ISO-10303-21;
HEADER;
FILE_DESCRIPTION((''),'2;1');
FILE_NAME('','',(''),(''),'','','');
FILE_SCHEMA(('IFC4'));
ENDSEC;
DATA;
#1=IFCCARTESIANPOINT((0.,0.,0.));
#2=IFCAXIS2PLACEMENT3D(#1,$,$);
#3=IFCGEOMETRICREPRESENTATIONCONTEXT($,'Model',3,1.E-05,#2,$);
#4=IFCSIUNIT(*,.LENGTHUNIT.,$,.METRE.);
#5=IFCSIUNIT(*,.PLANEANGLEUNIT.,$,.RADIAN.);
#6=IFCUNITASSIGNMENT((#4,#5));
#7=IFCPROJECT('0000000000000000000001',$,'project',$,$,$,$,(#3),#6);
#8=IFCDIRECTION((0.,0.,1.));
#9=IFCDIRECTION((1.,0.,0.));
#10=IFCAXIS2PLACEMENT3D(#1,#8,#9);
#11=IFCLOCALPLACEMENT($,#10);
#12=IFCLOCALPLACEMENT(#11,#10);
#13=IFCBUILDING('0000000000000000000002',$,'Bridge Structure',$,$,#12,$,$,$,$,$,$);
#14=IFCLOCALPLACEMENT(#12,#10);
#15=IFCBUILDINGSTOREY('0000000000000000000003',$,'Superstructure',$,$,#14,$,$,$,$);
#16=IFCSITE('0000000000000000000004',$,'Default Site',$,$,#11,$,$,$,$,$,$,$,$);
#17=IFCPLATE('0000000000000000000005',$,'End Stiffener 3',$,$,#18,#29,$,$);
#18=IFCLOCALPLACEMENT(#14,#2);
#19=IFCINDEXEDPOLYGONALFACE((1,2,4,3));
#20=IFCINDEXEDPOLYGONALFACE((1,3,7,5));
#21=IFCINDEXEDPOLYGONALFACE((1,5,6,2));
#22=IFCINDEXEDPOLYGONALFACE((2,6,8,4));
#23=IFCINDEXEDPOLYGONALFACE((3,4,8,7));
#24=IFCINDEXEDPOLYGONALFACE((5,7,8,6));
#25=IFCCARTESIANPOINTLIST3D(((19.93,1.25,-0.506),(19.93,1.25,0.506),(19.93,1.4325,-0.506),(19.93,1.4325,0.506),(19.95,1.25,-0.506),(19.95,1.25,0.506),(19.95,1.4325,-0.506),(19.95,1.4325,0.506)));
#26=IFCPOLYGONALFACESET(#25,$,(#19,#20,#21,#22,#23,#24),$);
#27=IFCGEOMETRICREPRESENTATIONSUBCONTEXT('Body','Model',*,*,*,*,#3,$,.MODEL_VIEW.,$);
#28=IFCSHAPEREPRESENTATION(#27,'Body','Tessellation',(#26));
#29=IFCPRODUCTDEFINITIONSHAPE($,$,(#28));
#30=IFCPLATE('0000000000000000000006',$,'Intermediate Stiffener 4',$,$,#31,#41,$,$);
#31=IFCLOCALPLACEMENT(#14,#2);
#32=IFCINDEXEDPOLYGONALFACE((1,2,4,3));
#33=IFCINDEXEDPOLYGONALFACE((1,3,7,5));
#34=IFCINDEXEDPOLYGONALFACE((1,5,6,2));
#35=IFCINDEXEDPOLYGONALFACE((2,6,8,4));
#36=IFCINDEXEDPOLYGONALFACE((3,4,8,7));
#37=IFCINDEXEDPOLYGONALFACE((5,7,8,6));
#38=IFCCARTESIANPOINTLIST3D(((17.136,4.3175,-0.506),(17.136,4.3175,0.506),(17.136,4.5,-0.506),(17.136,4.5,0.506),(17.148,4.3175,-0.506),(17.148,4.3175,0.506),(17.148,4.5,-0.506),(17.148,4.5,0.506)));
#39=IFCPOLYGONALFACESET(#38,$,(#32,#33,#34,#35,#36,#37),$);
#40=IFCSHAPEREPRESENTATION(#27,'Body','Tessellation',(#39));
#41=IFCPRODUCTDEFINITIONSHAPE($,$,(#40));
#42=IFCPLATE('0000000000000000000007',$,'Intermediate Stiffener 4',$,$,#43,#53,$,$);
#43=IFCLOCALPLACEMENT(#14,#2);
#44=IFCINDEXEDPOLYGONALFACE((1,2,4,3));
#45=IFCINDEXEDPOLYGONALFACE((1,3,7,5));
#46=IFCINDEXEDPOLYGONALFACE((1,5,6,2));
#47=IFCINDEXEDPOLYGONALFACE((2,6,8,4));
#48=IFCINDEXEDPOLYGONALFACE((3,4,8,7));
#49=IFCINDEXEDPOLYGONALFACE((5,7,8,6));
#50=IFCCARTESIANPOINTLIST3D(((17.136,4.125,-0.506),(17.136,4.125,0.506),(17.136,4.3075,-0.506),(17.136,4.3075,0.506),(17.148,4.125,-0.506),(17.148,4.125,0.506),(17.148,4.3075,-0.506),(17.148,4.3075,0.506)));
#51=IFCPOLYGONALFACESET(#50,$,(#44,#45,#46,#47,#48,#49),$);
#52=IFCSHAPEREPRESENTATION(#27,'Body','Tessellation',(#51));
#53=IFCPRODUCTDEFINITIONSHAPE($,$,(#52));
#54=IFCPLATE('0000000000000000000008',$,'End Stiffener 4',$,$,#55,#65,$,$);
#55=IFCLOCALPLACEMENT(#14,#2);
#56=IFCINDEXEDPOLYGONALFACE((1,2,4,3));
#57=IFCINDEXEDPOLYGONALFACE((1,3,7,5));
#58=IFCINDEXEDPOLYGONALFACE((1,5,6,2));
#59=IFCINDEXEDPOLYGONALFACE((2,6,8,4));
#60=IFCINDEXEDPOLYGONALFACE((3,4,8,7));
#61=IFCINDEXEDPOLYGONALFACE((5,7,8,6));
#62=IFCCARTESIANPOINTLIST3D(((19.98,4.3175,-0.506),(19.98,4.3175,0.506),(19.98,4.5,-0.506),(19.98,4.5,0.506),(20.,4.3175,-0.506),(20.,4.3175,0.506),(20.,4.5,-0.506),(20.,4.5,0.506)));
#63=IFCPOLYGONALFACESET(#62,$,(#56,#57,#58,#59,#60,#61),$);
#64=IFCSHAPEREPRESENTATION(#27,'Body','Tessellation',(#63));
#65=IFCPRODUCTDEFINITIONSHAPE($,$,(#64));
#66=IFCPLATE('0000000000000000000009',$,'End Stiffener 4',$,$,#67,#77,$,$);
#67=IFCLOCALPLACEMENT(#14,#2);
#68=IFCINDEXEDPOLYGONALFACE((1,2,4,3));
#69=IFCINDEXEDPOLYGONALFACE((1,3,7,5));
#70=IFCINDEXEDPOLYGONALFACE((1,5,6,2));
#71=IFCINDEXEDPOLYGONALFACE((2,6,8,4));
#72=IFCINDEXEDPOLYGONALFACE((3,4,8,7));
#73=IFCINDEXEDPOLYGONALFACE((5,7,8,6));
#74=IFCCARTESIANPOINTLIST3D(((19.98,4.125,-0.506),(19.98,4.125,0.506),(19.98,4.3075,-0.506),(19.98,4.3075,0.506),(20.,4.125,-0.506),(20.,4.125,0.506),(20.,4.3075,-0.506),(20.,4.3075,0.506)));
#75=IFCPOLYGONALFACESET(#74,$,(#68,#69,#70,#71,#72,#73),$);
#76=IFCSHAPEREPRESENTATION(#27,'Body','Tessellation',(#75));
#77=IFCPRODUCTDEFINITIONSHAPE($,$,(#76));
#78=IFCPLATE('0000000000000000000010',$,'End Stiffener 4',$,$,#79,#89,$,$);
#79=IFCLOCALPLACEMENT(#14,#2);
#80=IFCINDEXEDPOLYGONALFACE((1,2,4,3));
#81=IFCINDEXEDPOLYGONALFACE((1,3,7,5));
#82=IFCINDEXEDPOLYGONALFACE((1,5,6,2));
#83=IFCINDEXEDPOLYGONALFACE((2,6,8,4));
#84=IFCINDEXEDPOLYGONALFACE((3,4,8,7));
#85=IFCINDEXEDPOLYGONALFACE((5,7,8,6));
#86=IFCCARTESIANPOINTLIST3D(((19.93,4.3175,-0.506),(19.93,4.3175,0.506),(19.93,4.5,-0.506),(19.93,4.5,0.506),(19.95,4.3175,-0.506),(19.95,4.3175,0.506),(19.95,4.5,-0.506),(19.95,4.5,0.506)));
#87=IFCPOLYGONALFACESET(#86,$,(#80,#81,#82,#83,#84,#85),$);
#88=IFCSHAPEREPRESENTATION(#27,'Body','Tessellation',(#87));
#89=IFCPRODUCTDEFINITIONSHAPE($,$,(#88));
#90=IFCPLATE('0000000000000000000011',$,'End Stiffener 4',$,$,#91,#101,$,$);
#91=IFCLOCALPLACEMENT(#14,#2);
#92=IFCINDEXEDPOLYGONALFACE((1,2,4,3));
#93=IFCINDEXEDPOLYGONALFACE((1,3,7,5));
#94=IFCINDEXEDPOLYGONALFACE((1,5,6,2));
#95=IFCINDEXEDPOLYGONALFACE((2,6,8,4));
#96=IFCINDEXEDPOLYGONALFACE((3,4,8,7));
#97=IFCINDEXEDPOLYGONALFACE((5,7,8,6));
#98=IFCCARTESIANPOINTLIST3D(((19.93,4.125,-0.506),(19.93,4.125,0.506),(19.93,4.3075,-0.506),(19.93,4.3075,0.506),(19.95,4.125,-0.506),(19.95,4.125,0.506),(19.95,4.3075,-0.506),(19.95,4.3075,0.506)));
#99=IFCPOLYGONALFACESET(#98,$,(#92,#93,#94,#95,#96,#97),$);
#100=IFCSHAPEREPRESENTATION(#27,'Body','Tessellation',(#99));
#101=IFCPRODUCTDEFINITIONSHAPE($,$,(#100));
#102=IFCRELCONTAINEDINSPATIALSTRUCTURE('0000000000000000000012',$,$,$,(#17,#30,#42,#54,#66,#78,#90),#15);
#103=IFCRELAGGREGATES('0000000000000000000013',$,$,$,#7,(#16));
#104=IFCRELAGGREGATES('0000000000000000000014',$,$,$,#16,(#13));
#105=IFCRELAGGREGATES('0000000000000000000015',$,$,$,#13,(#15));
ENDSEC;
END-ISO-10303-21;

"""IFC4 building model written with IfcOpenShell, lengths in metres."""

from ifc_helpers import new_model, si_unit, frame, origin, origin_with_axes, origin_2d_with_axis, place, context, subcontext, project, spatial, rectangle, extrude, element, save


model = new_model("IFC4")

# Units and contexts
model_context = context("Model", 3, precision=1e-05, world=origin())
body_context = subcontext(model_context, "Body", "Model", "MODEL_VIEW")
ifc_project = project(units=[si_unit("LENGTHUNIT", "METRE"), si_unit("PLANEANGLEUNIT", "RADIAN")], contexts=[model_context])

# Site, building, storey
site_placement = place(None, origin_with_axes())
site = spatial("IfcSite", under=ifc_project, at=site_placement, Name="Default Site")
building_placement = place(site_placement, origin_with_axes())
building = spatial("IfcBuilding", under=site, at=building_placement, Name="Bridge Structure")
storey_placement = place(building_placement, origin_with_axes())
storey = spatial("IfcBuildingStorey", under=building, at=storey_placement, Name="Superstructure")

# Plates
for number, where, z_axis, x_axis, name in (
    (1, (19.94, 1.3413, -0.506), (0.0, 0.0, 1.0), (1.0, 0.0, 0.0), "End Stiffener 3"),
):
    element("IfcPlate", number, at=place(storey_placement, frame(where, z_axis=z_axis, x_axis=x_axis)), inside=storey, Name=name, context=body_context, shape_type="SweptSolid", body=[
        extrude(rectangle(XDim=0.02, YDim=0.1825, at=origin_2d_with_axis()), origin_with_axes(), (0.0, 0.0, 1.0), 1.012),
    ])
for number, where, z_axis, x_axis, name in (
    (2, (17.142, 4.4088, -0.506), (0.0, 0.0, 1.0), (1.0, 0.0, 0.0), "Intermediate Stiffener 4"),
    (3, (17.142, 4.2163, -0.506), (0.0, 0.0, 1.0), (1.0, 0.0, 0.0), "Intermediate Stiffener 4"),
):
    element("IfcPlate", number, at=place(storey_placement, frame(where, z_axis=z_axis, x_axis=x_axis)), inside=storey, Name=name, context=body_context, shape_type="SweptSolid", body=[
        extrude(rectangle(XDim=0.012, YDim=0.1825, at=origin_2d_with_axis()), origin_with_axes(), (0.0, 0.0, 1.0), 1.012),
    ])
for number, where, z_axis, x_axis, name in (
    (4, (19.99, 4.4088, -0.506), (0.0, 0.0, 1.0), (1.0, 0.0, 0.0), "End Stiffener 4"),
    (5, (19.99, 4.2163, -0.506), (0.0, 0.0, 1.0), (1.0, 0.0, 0.0), "End Stiffener 4"),
    (6, (19.94, 4.4088, -0.506), (0.0, 0.0, 1.0), (1.0, 0.0, 0.0), "End Stiffener 4"),
    (7, (19.94, 4.2163, -0.506), (0.0, 0.0, 1.0), (1.0, 0.0, 0.0), "End Stiffener 4"),
):
    element("IfcPlate", number, at=place(storey_placement, frame(where, z_axis=z_axis, x_axis=x_axis)), inside=storey, Name=name, context=body_context, shape_type="SweptSolid", body=[
        extrude(rectangle(XDim=0.02, YDim=0.1825, at=origin_2d_with_axis()), origin_with_axes(), (0.0, 0.0, 1.0), 1.012),
    ])

save(model, "model.ifc")
